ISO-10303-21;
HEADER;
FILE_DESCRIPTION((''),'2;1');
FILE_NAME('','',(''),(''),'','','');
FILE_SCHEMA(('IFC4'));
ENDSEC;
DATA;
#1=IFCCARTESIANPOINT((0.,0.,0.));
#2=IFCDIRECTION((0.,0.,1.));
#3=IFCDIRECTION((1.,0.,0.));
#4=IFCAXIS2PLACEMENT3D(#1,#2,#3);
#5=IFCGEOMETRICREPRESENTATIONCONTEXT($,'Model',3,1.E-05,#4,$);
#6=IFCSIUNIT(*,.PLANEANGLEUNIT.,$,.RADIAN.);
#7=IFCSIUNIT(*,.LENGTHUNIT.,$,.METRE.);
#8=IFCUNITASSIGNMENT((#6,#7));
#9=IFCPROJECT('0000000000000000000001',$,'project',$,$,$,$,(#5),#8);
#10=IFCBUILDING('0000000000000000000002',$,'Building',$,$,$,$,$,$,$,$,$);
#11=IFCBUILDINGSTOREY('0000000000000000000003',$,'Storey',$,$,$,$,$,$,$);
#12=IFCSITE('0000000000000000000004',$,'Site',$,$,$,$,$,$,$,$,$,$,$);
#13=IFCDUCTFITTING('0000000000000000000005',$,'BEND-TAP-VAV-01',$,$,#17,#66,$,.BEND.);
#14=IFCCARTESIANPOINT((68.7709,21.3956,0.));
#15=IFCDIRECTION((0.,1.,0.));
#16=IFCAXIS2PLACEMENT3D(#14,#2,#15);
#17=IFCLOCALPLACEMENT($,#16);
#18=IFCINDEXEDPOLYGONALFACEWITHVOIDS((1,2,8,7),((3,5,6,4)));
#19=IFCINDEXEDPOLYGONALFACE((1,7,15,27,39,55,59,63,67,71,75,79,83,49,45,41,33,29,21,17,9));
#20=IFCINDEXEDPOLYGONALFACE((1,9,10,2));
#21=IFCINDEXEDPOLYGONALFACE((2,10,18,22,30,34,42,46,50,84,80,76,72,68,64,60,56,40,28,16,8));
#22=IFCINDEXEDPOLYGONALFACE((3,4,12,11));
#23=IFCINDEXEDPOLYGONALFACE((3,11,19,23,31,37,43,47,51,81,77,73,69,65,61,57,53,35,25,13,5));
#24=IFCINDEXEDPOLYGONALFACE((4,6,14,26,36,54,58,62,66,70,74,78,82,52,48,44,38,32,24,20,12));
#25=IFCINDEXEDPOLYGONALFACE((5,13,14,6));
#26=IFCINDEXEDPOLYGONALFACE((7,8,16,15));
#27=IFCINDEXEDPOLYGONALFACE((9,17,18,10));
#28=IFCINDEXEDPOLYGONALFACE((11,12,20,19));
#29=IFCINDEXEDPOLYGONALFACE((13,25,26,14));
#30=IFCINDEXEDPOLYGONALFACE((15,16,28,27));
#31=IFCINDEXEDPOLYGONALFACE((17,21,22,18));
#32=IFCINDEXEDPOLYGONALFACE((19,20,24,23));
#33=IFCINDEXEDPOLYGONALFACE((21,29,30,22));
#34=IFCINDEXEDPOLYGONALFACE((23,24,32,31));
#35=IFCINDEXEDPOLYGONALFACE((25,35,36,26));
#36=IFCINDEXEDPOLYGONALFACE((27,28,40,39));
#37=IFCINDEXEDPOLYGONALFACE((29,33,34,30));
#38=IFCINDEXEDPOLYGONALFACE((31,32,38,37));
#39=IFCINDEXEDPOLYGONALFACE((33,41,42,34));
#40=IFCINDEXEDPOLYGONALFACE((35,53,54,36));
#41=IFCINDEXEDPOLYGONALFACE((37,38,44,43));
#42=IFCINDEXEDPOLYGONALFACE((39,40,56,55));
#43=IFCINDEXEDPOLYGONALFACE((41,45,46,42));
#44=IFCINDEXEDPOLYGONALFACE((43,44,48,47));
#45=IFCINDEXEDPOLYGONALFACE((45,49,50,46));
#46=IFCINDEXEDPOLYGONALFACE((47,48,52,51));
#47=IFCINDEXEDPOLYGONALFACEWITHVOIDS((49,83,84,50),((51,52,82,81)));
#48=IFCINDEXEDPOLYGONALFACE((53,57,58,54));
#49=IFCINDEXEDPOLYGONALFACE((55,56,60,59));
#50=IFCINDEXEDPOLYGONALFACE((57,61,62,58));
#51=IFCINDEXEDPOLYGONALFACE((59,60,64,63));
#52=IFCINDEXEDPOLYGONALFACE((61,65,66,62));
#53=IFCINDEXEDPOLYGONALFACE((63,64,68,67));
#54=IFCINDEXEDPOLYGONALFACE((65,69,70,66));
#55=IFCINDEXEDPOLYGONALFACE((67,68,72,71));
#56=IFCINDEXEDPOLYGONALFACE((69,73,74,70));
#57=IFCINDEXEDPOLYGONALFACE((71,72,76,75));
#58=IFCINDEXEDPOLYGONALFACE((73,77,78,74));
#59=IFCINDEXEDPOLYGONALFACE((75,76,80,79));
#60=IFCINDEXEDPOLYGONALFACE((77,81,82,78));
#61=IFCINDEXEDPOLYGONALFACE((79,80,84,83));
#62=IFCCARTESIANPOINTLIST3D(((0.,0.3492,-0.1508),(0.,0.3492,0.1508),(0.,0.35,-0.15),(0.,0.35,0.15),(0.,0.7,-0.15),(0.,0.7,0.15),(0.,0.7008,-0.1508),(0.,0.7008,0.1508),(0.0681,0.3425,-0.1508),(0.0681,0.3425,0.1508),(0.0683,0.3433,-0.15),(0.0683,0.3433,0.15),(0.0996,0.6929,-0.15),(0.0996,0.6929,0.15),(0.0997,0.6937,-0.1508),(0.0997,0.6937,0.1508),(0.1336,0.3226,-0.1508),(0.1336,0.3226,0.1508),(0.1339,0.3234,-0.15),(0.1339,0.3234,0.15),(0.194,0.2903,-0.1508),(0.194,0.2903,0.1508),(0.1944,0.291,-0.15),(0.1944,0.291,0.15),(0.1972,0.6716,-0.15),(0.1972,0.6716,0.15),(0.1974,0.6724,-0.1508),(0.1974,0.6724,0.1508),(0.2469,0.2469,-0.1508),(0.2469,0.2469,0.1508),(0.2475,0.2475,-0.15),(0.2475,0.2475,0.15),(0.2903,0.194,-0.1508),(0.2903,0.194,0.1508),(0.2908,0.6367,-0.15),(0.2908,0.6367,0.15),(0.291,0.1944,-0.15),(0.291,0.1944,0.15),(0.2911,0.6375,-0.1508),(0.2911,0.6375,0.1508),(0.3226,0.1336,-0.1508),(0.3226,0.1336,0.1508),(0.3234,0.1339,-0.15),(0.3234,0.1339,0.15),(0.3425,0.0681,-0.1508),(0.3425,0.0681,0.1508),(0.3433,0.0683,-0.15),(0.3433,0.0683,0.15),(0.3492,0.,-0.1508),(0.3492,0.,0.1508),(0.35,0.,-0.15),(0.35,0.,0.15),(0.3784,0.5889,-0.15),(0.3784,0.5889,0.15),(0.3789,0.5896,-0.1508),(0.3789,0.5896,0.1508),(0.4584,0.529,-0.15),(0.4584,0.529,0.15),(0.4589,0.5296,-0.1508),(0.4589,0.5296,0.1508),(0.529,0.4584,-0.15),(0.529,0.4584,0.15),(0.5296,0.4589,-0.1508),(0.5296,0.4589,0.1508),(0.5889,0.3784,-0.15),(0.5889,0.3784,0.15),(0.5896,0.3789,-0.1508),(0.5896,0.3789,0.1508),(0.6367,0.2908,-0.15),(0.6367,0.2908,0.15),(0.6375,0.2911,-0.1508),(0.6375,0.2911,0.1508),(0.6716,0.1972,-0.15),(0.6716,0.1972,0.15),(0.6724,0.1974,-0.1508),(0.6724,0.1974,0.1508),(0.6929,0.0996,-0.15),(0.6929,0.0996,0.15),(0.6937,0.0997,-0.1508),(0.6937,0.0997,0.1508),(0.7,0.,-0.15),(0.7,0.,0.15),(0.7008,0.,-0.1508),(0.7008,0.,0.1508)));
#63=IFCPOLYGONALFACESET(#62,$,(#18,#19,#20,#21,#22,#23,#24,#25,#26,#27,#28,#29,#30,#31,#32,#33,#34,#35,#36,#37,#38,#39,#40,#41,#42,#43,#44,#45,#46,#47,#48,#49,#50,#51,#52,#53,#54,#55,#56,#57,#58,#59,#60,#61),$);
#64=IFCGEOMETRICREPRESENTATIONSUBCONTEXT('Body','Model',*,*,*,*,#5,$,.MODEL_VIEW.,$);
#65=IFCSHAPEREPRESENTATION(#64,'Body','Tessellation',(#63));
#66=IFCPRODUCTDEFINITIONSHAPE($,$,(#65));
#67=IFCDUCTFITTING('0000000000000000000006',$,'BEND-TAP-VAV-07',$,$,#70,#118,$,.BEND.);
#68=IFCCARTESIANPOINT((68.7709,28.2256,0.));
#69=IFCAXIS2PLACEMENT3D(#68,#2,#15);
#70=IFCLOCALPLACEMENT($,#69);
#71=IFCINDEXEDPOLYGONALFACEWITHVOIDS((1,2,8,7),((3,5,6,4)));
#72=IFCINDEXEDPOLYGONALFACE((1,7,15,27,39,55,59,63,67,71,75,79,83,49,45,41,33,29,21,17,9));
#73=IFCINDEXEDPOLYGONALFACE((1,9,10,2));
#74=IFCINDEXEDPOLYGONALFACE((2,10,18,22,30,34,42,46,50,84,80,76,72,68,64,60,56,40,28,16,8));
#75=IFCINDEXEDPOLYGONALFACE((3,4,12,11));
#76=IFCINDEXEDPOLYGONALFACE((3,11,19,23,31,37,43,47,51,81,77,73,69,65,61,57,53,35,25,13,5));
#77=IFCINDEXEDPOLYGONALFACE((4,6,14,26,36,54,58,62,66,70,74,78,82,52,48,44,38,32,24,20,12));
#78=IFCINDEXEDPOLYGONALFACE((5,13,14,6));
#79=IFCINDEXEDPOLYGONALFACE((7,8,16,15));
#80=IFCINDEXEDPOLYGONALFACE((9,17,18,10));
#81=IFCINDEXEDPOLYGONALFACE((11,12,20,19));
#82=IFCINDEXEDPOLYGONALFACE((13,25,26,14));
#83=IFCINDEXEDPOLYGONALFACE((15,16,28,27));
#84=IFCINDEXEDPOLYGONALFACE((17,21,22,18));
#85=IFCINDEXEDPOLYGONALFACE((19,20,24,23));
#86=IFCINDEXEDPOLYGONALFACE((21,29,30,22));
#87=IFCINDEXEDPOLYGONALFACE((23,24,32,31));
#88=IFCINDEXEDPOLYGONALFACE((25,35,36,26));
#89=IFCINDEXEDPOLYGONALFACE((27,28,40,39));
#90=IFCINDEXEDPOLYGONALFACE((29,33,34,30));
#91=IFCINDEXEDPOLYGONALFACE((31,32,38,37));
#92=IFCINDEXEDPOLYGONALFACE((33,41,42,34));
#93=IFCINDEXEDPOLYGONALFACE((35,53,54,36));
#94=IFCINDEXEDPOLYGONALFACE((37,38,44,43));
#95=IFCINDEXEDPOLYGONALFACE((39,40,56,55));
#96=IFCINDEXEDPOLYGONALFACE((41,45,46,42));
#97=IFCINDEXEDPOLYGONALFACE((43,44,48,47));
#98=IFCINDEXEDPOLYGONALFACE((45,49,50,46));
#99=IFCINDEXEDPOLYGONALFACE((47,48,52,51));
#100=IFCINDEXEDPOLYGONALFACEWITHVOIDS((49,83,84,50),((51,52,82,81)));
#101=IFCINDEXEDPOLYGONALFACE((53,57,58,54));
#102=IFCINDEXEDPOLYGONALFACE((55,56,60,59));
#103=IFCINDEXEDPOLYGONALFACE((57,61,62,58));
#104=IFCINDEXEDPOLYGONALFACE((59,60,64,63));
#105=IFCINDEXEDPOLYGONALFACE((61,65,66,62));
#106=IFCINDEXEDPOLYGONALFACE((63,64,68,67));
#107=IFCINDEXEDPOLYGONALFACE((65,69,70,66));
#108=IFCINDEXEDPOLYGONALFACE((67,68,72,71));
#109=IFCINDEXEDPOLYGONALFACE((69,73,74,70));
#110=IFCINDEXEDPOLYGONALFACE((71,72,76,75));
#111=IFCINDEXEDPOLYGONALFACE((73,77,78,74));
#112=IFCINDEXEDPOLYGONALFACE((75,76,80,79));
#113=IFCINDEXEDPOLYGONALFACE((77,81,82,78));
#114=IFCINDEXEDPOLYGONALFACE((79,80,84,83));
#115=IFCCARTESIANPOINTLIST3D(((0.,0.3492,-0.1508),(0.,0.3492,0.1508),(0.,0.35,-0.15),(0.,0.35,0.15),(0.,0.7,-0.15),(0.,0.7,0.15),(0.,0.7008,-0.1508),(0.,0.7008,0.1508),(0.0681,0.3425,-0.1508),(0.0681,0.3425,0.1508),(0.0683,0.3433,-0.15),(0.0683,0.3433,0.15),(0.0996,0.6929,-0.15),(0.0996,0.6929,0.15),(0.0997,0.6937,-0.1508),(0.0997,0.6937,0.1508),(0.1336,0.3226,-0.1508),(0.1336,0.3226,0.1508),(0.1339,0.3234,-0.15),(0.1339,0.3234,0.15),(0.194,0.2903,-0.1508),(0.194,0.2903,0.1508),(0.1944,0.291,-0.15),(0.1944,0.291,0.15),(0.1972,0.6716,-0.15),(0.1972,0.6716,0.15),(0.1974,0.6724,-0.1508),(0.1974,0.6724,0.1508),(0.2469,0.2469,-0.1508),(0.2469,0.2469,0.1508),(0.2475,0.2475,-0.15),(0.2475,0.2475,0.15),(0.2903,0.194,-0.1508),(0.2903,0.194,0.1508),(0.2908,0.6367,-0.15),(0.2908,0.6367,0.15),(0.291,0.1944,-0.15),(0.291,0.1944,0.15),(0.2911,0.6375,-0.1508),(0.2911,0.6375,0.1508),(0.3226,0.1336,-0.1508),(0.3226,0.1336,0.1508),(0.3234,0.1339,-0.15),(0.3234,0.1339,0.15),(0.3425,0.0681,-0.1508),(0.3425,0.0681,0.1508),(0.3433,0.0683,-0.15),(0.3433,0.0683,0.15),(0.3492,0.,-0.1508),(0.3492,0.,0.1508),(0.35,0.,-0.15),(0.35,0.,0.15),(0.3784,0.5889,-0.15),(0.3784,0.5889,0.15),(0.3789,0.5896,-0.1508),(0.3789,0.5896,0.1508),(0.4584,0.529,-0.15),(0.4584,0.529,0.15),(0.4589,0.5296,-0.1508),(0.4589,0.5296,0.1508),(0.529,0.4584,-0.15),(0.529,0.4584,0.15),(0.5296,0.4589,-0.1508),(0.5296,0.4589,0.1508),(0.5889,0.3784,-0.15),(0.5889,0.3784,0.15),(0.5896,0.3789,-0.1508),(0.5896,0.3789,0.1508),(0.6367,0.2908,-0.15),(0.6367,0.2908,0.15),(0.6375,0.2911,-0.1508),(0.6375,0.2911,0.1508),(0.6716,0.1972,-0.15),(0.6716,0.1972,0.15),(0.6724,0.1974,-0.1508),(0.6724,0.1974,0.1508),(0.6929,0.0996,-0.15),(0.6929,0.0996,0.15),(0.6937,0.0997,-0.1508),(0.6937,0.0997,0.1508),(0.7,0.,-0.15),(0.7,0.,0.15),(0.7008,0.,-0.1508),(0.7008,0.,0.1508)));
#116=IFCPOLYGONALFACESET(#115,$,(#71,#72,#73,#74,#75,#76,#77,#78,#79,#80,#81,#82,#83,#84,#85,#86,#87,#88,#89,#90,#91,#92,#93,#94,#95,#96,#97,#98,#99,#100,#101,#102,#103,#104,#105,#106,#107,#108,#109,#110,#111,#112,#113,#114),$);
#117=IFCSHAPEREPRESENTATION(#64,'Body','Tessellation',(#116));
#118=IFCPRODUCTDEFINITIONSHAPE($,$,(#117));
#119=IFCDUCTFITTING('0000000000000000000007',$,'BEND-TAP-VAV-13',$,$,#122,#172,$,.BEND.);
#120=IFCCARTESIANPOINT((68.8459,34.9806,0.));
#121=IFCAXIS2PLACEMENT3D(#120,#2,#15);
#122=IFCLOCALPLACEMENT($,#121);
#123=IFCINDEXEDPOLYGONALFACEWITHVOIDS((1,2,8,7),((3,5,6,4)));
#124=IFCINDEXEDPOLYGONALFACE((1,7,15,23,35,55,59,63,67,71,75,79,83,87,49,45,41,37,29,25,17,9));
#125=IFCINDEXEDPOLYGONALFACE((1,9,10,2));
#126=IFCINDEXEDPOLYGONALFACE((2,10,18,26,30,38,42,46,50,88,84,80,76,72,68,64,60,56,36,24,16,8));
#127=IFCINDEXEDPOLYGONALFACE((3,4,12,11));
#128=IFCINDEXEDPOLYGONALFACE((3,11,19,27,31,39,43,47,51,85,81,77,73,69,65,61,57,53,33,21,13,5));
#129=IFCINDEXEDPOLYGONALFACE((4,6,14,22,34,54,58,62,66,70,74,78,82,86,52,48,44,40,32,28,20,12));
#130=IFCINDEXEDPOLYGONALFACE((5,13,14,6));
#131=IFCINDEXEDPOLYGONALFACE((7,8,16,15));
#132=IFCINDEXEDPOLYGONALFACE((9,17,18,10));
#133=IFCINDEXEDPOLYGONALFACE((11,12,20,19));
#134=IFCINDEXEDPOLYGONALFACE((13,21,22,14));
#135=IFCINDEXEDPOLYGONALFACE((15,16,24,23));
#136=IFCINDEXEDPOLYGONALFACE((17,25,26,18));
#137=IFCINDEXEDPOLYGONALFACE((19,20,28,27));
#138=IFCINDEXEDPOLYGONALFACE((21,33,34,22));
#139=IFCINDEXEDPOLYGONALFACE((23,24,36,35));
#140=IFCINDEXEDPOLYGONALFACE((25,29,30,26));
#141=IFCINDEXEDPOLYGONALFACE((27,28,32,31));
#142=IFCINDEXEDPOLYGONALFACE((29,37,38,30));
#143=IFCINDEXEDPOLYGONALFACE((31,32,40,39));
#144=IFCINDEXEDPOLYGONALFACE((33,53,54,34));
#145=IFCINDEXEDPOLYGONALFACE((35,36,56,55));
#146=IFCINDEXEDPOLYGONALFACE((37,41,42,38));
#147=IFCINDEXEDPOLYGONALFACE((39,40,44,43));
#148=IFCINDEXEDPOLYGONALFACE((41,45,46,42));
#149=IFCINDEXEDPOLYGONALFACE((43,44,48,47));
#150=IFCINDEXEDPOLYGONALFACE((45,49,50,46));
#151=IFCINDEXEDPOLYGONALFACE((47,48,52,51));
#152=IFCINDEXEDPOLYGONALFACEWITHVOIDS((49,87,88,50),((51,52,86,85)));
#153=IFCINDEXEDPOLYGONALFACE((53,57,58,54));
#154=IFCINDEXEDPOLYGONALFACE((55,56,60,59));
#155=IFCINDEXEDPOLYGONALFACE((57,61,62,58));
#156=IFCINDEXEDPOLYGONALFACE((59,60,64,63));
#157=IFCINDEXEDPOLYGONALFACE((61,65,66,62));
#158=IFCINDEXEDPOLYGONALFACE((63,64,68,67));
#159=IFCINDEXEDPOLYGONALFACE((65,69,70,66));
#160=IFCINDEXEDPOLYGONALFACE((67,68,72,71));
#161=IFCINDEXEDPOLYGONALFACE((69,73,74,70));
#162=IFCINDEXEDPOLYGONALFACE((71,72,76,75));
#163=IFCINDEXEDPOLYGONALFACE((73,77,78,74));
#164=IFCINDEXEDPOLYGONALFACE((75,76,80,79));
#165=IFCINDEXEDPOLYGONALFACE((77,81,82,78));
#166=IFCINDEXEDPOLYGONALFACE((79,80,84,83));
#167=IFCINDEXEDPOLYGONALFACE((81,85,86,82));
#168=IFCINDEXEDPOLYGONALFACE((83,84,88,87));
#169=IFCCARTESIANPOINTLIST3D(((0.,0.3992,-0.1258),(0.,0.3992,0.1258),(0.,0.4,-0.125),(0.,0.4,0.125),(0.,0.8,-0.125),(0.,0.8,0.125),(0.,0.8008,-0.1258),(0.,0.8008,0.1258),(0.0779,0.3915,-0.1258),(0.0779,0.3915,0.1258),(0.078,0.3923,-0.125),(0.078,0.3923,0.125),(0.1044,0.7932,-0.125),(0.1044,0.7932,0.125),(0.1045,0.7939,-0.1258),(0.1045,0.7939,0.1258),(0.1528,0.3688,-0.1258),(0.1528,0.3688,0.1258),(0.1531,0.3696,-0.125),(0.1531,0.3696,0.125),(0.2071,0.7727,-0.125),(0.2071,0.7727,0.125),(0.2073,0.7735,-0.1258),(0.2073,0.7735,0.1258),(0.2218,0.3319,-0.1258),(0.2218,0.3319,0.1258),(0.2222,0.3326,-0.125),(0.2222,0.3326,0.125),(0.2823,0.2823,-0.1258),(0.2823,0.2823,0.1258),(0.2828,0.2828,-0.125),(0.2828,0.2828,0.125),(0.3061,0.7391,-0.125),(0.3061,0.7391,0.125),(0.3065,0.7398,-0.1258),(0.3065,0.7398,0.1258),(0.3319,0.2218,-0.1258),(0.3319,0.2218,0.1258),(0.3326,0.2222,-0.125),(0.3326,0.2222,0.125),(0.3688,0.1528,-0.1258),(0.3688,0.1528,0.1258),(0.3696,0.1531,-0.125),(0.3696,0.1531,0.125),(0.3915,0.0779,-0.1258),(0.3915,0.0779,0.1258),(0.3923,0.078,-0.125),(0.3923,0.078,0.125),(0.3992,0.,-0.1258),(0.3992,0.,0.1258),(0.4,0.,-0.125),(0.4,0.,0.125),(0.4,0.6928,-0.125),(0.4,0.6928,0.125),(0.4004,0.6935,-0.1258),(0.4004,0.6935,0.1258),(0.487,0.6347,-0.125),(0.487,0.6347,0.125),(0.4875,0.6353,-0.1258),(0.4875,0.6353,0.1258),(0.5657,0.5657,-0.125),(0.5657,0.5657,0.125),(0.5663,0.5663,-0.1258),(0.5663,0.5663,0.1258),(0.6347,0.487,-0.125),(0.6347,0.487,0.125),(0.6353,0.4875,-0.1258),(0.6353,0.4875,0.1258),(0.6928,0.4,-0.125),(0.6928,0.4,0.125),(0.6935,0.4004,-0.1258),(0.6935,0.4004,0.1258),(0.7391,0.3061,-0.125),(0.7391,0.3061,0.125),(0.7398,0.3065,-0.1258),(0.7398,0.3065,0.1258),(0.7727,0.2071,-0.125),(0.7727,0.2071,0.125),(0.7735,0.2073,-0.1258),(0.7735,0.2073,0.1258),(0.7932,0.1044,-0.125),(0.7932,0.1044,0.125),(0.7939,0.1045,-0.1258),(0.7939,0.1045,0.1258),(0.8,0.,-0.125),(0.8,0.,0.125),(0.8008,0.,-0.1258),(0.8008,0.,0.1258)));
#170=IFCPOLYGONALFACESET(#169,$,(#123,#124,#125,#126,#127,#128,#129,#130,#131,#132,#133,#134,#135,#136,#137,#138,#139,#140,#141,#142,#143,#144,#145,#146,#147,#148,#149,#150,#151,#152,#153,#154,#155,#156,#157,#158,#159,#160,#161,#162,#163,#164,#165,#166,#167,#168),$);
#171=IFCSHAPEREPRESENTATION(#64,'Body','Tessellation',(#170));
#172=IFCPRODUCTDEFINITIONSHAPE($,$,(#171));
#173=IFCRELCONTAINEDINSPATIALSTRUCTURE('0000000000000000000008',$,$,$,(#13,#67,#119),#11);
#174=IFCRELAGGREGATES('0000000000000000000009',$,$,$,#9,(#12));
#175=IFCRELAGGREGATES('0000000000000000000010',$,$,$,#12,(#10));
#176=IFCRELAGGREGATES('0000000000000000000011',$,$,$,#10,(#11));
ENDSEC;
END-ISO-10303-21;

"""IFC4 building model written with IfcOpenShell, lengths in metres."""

from ifc_helpers import new_model, entity, si_unit, frame, origin_with_axes, place, context, subcontext, project, spatial, element, save


model = new_model("IFC4")

# Units and contexts
model_context = context("Model", 3, precision=1e-05, world=origin_with_axes())
body_context = subcontext(model_context, "Body", "Model", "MODEL_VIEW")
ifc_project = project(units=[si_unit("PLANEANGLEUNIT", "RADIAN"), si_unit("LENGTHUNIT", "METRE")], contexts=[model_context])

# Site, building, storey
site = spatial("IfcSite", under=ifc_project, Name="Site")
building = spatial("IfcBuilding", under=site, Name="Building")
storey = spatial("IfcBuildingStorey", under=building, Name="Storey")

# Duct fittings
duct_fitting_1_placement = place(None, frame((68.7709, 21.3956, 0.0), z_axis=(0.0, 0.0, 1.0), x_axis=(0.0, 1.0, 0.0)))
cartesian_point_1 = entity("IfcCartesianPoint", [0.0, 0.0, 0.0])
element("IfcDuctFitting", 1, at=duct_fitting_1_placement, inside=storey, Name="BEND-TAP-VAV-01", PredefinedType="BEND", context=body_context, shape_type="SweptSolid", body=[
    entity("IfcRevolvedAreaSolid", entity("IfcRectangleHollowProfileDef", "AREA", None, entity("IfcAxis2Placement2D", entity("IfcCartesianPoint", [0.525, 0.0])), 0.3516, 0.3016, 0.0008), entity("IfcAxis2Placement3D", cartesian_point_1, entity("IfcDirection", [0.0, -1.0, 0.0]), entity("IfcDirection", [1.0, 0.0, 0.0])), entity("IfcAxis1Placement", cartesian_point_1, entity("IfcDirection", [0.0, 1.0, 0.0])), 1.570796),
])
duct_fitting_2_placement = place(None, frame((68.7709, 28.2256, 0.0), z_axis=(0.0, 0.0, 1.0), x_axis=(0.0, 1.0, 0.0)))
cartesian_point_2 = entity("IfcCartesianPoint", [0.0, 0.0, 0.0])
element("IfcDuctFitting", 2, at=duct_fitting_2_placement, inside=storey, Name="BEND-TAP-VAV-07", PredefinedType="BEND", context=body_context, shape_type="SweptSolid", body=[
    entity("IfcRevolvedAreaSolid", entity("IfcRectangleHollowProfileDef", "AREA", None, entity("IfcAxis2Placement2D", entity("IfcCartesianPoint", [0.525, 0.0])), 0.3516, 0.3016, 0.0008), entity("IfcAxis2Placement3D", cartesian_point_2, entity("IfcDirection", [0.0, -1.0, 0.0]), entity("IfcDirection", [1.0, 0.0, 0.0])), entity("IfcAxis1Placement", cartesian_point_2, entity("IfcDirection", [0.0, 1.0, 0.0])), 1.570796),
])
duct_fitting_3_placement = place(None, frame((68.8459, 34.9806, 0.0), z_axis=(0.0, 0.0, 1.0), x_axis=(0.0, 1.0, 0.0)))
cartesian_point_3 = entity("IfcCartesianPoint", [0.0, 0.0, 0.0])
element("IfcDuctFitting", 3, at=duct_fitting_3_placement, inside=storey, Name="BEND-TAP-VAV-13", PredefinedType="BEND", context=body_context, shape_type="SweptSolid", body=[
    entity("IfcRevolvedAreaSolid", entity("IfcRectangleHollowProfileDef", "AREA", None, entity("IfcAxis2Placement2D", entity("IfcCartesianPoint", [0.6, 0.0])), 0.4016, 0.2516, 0.0008), entity("IfcAxis2Placement3D", cartesian_point_3, entity("IfcDirection", [0.0, -1.0, 0.0]), entity("IfcDirection", [1.0, 0.0, 0.0])), entity("IfcAxis1Placement", cartesian_point_3, entity("IfcDirection", [0.0, 1.0, 0.0])), 1.570796),
])

save(model, "model.ifc")
